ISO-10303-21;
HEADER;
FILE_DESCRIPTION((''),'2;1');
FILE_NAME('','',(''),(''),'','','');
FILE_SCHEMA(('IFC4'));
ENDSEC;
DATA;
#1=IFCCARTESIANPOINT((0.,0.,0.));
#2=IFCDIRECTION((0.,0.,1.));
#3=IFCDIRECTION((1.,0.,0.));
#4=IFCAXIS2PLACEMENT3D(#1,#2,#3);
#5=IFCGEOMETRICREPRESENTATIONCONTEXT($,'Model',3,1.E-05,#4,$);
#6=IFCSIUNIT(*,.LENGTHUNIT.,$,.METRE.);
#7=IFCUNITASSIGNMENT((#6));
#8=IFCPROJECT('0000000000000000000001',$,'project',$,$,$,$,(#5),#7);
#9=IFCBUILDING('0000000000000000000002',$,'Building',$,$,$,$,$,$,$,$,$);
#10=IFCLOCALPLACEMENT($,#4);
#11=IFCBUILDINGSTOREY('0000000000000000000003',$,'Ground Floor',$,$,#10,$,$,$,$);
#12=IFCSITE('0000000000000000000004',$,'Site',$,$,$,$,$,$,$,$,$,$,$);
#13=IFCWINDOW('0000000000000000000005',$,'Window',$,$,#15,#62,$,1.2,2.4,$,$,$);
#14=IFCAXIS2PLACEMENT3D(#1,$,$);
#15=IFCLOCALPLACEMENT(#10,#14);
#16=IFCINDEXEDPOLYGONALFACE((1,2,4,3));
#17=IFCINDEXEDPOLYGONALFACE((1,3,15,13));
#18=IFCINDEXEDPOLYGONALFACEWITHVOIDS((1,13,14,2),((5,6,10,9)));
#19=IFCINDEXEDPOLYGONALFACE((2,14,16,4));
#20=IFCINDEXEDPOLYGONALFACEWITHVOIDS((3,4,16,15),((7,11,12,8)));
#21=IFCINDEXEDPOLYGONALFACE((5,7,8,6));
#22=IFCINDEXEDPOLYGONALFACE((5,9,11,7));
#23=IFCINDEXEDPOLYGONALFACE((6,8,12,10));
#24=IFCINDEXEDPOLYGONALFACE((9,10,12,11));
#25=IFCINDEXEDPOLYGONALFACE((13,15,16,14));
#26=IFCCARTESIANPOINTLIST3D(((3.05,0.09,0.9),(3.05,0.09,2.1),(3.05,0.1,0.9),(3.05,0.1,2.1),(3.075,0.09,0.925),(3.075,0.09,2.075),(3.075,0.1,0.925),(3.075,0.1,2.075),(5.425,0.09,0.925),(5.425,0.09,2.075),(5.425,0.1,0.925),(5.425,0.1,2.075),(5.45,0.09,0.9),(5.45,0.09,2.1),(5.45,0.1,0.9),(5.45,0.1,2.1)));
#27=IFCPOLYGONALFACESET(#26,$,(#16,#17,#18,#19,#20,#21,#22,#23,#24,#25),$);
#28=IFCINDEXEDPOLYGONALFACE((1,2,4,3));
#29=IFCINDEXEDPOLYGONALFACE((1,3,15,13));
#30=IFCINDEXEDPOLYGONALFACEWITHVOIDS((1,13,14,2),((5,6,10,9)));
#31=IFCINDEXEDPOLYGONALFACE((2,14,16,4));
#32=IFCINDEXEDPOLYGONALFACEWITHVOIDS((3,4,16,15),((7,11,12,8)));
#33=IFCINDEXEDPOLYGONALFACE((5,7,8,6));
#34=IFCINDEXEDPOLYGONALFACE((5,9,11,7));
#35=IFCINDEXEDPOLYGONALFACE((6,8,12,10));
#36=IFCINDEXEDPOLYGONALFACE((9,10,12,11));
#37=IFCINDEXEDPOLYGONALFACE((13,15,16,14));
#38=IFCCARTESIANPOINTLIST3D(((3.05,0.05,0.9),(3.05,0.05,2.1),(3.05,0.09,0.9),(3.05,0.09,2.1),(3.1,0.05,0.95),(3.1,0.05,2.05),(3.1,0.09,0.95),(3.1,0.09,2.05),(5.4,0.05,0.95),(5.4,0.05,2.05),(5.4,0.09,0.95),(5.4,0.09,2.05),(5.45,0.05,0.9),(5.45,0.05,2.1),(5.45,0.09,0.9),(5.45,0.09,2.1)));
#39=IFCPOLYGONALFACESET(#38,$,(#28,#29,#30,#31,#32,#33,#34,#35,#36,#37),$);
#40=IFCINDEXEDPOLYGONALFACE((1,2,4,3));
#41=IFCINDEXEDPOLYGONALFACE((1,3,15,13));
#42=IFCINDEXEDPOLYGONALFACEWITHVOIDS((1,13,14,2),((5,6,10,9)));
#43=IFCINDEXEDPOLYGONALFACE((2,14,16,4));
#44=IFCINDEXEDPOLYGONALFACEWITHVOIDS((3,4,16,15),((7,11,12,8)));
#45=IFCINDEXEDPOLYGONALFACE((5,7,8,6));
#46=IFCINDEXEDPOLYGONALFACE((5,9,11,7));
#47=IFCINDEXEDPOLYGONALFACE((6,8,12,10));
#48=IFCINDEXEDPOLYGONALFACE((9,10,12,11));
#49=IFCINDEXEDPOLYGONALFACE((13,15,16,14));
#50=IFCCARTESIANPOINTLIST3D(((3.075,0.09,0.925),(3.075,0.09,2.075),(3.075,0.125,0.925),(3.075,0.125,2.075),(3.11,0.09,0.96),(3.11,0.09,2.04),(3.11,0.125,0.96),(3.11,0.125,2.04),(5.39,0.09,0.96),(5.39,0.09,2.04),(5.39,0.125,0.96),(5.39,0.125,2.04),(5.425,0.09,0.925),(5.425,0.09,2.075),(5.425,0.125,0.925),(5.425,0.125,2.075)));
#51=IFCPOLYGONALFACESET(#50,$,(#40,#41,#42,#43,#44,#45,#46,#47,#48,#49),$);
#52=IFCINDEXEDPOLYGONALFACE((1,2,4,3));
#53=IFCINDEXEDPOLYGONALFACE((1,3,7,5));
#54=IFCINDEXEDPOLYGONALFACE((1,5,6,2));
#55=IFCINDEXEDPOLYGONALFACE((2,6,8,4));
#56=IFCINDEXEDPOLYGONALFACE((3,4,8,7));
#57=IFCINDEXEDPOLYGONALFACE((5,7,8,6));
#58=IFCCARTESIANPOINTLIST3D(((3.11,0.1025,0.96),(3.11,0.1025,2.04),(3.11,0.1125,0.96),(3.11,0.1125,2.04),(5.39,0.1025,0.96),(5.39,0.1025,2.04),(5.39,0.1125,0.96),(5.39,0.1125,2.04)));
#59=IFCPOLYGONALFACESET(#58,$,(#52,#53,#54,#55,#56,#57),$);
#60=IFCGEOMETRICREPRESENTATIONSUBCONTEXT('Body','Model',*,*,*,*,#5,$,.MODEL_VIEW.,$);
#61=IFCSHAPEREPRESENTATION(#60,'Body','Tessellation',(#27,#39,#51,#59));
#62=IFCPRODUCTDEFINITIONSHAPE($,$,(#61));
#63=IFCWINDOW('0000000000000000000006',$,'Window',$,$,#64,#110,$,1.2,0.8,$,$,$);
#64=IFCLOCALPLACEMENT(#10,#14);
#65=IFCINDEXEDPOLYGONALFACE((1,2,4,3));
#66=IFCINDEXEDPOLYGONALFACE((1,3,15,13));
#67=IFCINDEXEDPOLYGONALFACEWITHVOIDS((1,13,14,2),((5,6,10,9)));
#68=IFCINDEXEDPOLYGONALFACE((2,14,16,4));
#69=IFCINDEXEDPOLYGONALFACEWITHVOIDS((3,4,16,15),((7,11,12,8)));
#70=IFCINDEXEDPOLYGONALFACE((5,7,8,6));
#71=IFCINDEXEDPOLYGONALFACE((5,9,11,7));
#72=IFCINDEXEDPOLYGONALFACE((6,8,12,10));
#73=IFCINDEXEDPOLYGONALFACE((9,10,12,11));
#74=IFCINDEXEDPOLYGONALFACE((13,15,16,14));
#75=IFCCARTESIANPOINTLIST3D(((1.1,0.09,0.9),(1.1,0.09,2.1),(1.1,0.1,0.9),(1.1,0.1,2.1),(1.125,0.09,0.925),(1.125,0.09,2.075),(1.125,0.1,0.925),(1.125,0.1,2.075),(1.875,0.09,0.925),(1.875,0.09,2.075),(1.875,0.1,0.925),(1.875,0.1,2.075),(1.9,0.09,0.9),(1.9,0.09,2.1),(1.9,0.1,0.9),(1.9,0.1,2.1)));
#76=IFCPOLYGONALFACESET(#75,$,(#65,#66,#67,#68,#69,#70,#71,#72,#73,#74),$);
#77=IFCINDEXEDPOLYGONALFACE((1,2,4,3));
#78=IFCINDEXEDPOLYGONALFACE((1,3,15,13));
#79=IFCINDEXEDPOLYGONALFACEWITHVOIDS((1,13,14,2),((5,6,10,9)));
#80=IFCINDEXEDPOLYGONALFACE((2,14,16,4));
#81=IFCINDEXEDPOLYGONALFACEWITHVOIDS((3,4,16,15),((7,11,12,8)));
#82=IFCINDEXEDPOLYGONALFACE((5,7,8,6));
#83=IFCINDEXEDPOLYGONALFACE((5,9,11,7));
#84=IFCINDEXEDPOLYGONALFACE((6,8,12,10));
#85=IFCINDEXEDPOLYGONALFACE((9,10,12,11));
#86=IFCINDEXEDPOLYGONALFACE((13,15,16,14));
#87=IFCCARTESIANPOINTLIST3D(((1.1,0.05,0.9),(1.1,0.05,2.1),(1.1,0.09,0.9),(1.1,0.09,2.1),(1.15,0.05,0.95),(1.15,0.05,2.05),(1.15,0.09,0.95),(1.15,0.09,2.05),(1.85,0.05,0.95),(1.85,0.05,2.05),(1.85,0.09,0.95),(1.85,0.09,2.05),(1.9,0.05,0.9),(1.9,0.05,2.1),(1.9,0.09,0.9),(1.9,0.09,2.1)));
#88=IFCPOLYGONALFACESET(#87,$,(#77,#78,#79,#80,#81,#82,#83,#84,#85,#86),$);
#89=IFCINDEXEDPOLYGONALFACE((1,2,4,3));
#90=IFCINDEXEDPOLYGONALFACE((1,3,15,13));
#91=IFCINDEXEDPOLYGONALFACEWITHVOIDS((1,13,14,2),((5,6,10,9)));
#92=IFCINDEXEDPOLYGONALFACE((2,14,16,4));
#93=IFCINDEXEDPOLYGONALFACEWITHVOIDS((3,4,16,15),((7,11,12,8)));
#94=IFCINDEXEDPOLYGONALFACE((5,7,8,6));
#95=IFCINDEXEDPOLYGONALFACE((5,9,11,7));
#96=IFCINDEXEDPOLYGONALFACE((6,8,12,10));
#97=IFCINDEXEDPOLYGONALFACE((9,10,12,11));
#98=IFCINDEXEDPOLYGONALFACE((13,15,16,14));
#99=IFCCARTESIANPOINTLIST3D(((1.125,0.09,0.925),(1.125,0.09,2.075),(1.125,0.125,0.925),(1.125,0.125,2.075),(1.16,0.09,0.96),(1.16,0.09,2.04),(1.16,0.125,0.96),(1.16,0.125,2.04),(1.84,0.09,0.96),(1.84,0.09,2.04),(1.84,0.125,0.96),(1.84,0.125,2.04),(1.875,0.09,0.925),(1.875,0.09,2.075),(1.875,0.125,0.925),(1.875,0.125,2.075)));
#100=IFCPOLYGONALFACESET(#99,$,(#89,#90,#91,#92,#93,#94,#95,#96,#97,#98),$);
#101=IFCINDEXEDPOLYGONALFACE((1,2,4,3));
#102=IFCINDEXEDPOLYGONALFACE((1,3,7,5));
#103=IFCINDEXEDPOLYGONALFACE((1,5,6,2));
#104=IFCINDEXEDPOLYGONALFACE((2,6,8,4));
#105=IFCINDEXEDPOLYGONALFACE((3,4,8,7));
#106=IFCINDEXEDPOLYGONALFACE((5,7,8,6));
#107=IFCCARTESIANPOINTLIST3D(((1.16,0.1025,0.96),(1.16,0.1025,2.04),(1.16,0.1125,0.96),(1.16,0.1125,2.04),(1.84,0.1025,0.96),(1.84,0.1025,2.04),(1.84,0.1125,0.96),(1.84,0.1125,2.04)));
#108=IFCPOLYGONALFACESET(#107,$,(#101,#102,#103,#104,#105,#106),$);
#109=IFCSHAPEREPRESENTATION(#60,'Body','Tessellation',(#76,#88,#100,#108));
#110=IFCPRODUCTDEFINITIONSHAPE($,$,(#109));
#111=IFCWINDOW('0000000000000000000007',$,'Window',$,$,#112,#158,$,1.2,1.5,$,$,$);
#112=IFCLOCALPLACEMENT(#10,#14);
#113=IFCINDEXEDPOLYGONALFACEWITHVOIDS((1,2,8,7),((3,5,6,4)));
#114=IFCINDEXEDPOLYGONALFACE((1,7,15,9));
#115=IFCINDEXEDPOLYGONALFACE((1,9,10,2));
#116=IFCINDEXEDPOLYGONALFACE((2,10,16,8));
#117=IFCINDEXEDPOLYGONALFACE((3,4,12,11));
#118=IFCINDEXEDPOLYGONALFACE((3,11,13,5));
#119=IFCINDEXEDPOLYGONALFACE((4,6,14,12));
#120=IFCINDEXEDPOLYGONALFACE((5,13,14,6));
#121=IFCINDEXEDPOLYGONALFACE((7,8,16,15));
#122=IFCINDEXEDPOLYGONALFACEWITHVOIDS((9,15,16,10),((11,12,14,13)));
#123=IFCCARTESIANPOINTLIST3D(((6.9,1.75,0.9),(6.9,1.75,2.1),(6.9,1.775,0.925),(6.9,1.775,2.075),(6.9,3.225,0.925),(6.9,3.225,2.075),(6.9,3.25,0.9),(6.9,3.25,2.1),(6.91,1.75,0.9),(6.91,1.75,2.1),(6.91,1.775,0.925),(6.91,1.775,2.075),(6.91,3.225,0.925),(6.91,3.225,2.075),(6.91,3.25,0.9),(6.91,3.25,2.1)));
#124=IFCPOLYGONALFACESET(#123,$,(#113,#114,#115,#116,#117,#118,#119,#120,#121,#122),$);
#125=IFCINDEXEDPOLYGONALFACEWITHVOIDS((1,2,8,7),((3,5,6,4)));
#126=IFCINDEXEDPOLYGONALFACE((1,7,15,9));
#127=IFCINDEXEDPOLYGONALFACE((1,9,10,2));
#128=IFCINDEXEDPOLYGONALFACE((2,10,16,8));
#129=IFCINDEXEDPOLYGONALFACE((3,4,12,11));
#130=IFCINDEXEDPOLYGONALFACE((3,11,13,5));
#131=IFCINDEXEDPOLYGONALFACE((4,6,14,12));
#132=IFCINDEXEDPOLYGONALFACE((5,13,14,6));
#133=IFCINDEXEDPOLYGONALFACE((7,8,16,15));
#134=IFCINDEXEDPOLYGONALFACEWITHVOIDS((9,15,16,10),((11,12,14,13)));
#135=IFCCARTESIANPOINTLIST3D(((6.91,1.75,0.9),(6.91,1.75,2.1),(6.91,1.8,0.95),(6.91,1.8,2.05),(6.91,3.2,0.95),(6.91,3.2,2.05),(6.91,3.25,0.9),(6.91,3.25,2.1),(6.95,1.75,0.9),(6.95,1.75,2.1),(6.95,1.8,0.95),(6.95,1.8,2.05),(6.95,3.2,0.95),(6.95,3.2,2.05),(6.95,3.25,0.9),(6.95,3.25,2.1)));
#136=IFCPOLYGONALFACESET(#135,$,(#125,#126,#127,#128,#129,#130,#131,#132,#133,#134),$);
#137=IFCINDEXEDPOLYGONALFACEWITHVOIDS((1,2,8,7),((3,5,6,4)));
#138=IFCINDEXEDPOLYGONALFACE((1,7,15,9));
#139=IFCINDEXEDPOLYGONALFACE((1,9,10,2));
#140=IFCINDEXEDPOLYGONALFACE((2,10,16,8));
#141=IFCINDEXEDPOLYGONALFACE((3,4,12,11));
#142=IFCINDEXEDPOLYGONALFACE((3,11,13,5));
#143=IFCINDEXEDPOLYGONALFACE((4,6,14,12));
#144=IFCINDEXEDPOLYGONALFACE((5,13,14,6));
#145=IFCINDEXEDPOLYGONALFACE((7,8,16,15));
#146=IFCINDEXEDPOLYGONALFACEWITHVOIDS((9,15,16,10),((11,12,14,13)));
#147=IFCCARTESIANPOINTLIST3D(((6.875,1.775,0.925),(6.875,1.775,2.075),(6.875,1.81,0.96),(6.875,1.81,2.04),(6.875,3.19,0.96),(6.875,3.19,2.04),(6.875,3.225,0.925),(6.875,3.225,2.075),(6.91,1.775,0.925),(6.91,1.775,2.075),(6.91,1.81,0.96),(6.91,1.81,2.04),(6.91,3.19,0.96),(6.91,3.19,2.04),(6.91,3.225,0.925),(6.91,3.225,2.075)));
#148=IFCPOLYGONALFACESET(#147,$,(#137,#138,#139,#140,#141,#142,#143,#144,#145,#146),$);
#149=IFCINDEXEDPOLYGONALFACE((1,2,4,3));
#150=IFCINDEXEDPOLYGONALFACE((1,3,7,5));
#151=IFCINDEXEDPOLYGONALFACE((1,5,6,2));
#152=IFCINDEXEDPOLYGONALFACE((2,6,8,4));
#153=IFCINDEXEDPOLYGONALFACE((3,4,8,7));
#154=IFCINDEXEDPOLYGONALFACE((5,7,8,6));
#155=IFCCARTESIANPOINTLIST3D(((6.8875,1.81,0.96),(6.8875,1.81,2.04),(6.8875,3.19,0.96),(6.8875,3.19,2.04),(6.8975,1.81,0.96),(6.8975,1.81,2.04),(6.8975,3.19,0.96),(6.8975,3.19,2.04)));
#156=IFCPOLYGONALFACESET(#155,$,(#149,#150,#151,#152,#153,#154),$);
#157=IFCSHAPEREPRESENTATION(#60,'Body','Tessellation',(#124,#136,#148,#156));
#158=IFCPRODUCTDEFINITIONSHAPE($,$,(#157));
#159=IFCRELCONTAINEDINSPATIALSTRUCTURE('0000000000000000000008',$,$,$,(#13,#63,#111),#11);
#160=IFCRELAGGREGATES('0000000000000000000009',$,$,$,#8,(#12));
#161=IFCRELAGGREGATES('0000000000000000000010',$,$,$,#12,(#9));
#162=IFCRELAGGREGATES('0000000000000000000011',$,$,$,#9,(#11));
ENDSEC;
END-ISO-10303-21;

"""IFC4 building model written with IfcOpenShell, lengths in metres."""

from ifc_helpers import new_model, si_unit, frame, origin_with_axes, place, context, subcontext, project, spatial, line, indexed_curve, outline, extrude, element, save


model = new_model("IFC4")

# Units and contexts
model_context = context("Model", 3, precision=1e-05, world=origin_with_axes())
body_context = subcontext(model_context, "Body", "Model", "MODEL_VIEW")
ifc_project = project(units=[si_unit("LENGTHUNIT", "METRE")], contexts=[model_context])

# Site, building, storey
site = spatial("IfcSite", under=ifc_project, Name="Site")
building = spatial("IfcBuilding", under=site, Name="Building")
storey_placement = place(None, origin_with_axes())
storey = spatial("IfcBuildingStorey", under=building, at=storey_placement, Name="Ground Floor")

# Windows
window_1_placement = place(storey_placement, frame((3.05, 0.0, 0.9), z_axis=(0.0, 0.0, 1.0), x_axis=(1.0, 0.0, 0.0)))
element("IfcWindow", 1, at=window_1_placement, inside=storey, Name="Window", OverallHeight=1.2, OverallWidth=2.4, context=body_context, shape_type="SweptSolid", body=[
    extrude(outline(indexed_curve([(0.0, 0.0), (2.4, 0.0), (2.4, 1.2), (0.0, 1.2)], segments=[line(1, 2, 3, 4, 1)]), holes=[indexed_curve([(0.025, 0.025), (2.375, 0.025), (2.375, 1.175), (0.025, 1.175)], segments=[line(1, 2, 3, 4, 1)])]), frame((0.0, 0.09, 0.0), z_axis=(0.0, -1.0, 0.0), x_axis=(1.0, 0.0, 0.0)), (0.0, 0.0, -1.0), 0.01),
    extrude(outline(indexed_curve([(0.0, 0.0), (2.4, 0.0), (2.4, 1.2), (0.0, 1.2)], segments=[line(1, 2, 3, 4, 1)]), holes=[indexed_curve([(0.05, 0.05), (2.35, 0.05), (2.35, 1.15), (0.05, 1.15)], segments=[line(1, 2, 3, 4, 1)])]), frame((0.0, 0.05, 0.0), z_axis=(0.0, -1.0, 0.0), x_axis=(1.0, 0.0, 0.0)), (0.0, 0.0, -1.0), 0.04),
    extrude(outline(indexed_curve([(0.0, 0.0), (2.35, 0.0), (2.35, 1.15), (0.0, 1.15)], segments=[line(1, 2, 3, 4, 1)]), holes=[indexed_curve([(0.035, 0.035), (2.315, 0.035), (2.315, 1.115), (0.035, 1.115)], segments=[line(1, 2, 3, 4, 1)])]), frame((0.025, 0.09, 0.025), z_axis=(0.0, -1.0, 0.0), x_axis=(1.0, 0.0, 0.0)), (0.0, 0.0, -1.0), 0.035),
    extrude(outline(indexed_curve([(0.035, 0.035), (2.315, 0.035), (2.315, 1.115), (0.035, 1.115)], segments=[line(1, 2, 3, 4, 1)])), frame((0.025, 0.1025, 0.025), z_axis=(0.0, -1.0, 0.0), x_axis=(1.0, 0.0, 0.0)), (0.0, 0.0, -1.0), 0.01),
])
window_2_placement = place(storey_placement, frame((1.1, 0.0, 0.9), z_axis=(0.0, 0.0, 1.0), x_axis=(1.0, 0.0, 0.0)))
element("IfcWindow", 2, at=window_2_placement, inside=storey, Name="Window", OverallHeight=1.2, OverallWidth=0.8, context=body_context, shape_type="SweptSolid", body=[
    extrude(outline(indexed_curve([(0.0, 0.0), (0.8, 0.0), (0.8, 1.2), (0.0, 1.2)], segments=[line(1, 2, 3, 4, 1)]), holes=[indexed_curve([(0.025, 0.025), (0.775, 0.025), (0.775, 1.175), (0.025, 1.175)], segments=[line(1, 2, 3, 4, 1)])]), frame((0.0, 0.09, 0.0), z_axis=(0.0, -1.0, 0.0), x_axis=(1.0, 0.0, 0.0)), (0.0, 0.0, -1.0), 0.01),
    extrude(outline(indexed_curve([(0.0, 0.0), (0.8, 0.0), (0.8, 1.2), (0.0, 1.2)], segments=[line(1, 2, 3, 4, 1)]), holes=[indexed_curve([(0.05, 0.05), (0.75, 0.05), (0.75, 1.15), (0.05, 1.15)], segments=[line(1, 2, 3, 4, 1)])]), frame((0.0, 0.05, 0.0), z_axis=(0.0, -1.0, 0.0), x_axis=(1.0, 0.0, 0.0)), (0.0, 0.0, -1.0), 0.04),
    extrude(outline(indexed_curve([(0.0, 0.0), (0.75, 0.0), (0.75, 1.15), (0.0, 1.15)], segments=[line(1, 2, 3, 4, 1)]), holes=[indexed_curve([(0.035, 0.035), (0.715, 0.035), (0.715, 1.115), (0.035, 1.115)], segments=[line(1, 2, 3, 4, 1)])]), frame((0.025, 0.09, 0.025), z_axis=(0.0, -1.0, 0.0), x_axis=(1.0, 0.0, 0.0)), (0.0, 0.0, -1.0), 0.035),
    extrude(outline(indexed_curve([(0.035, 0.035), (0.715, 0.035), (0.715, 1.115), (0.035, 1.115)], segments=[line(1, 2, 3, 4, 1)])), frame((0.025, 0.1025, 0.025), z_axis=(0.0, -1.0, 0.0), x_axis=(1.0, 0.0, 0.0)), (0.0, 0.0, -1.0), 0.01),
])
window_3_placement = place(storey_placement, frame((7.0, 1.75, 0.9), z_axis=(0.0, 0.0, 1.0), x_axis=(0.0, 1.0, 0.0)))
element("IfcWindow", 3, at=window_3_placement, inside=storey, Name="Window", OverallHeight=1.2, OverallWidth=1.5, context=body_context, shape_type="SweptSolid", body=[
    extrude(outline(indexed_curve([(0.0, 0.0), (1.5, 0.0), (1.5, 1.2), (0.0, 1.2)], segments=[line(1, 2, 3, 4, 1)]), holes=[indexed_curve([(0.025, 0.025), (1.475, 0.025), (1.475, 1.175), (0.025, 1.175)], segments=[line(1, 2, 3, 4, 1)])]), frame((0.0, 0.09, 0.0), z_axis=(0.0, -1.0, 0.0), x_axis=(1.0, 0.0, 0.0)), (0.0, 0.0, -1.0), 0.01),
    extrude(outline(indexed_curve([(0.0, 0.0), (1.5, 0.0), (1.5, 1.2), (0.0, 1.2)], segments=[line(1, 2, 3, 4, 1)]), holes=[indexed_curve([(0.05, 0.05), (1.45, 0.05), (1.45, 1.15), (0.05, 1.15)], segments=[line(1, 2, 3, 4, 1)])]), frame((0.0, 0.05, 0.0), z_axis=(0.0, -1.0, 0.0), x_axis=(1.0, 0.0, 0.0)), (0.0, 0.0, -1.0), 0.04),
    extrude(outline(indexed_curve([(0.0, 0.0), (1.45, 0.0), (1.45, 1.15), (0.0, 1.15)], segments=[line(1, 2, 3, 4, 1)]), holes=[indexed_curve([(0.035, 0.035), (1.415, 0.035), (1.415, 1.115), (0.035, 1.115)], segments=[line(1, 2, 3, 4, 1)])]), frame((0.025, 0.09, 0.025), z_axis=(0.0, -1.0, 0.0), x_axis=(1.0, 0.0, 0.0)), (0.0, 0.0, -1.0), 0.035),
    extrude(outline(indexed_curve([(0.035, 0.035), (1.415, 0.035), (1.415, 1.115), (0.035, 1.115)], segments=[line(1, 2, 3, 4, 1)])), frame((0.025, 0.1025, 0.025), z_axis=(0.0, -1.0, 0.0), x_axis=(1.0, 0.0, 0.0)), (0.0, 0.0, -1.0), 0.01),
])

save(model, "model.ifc")
